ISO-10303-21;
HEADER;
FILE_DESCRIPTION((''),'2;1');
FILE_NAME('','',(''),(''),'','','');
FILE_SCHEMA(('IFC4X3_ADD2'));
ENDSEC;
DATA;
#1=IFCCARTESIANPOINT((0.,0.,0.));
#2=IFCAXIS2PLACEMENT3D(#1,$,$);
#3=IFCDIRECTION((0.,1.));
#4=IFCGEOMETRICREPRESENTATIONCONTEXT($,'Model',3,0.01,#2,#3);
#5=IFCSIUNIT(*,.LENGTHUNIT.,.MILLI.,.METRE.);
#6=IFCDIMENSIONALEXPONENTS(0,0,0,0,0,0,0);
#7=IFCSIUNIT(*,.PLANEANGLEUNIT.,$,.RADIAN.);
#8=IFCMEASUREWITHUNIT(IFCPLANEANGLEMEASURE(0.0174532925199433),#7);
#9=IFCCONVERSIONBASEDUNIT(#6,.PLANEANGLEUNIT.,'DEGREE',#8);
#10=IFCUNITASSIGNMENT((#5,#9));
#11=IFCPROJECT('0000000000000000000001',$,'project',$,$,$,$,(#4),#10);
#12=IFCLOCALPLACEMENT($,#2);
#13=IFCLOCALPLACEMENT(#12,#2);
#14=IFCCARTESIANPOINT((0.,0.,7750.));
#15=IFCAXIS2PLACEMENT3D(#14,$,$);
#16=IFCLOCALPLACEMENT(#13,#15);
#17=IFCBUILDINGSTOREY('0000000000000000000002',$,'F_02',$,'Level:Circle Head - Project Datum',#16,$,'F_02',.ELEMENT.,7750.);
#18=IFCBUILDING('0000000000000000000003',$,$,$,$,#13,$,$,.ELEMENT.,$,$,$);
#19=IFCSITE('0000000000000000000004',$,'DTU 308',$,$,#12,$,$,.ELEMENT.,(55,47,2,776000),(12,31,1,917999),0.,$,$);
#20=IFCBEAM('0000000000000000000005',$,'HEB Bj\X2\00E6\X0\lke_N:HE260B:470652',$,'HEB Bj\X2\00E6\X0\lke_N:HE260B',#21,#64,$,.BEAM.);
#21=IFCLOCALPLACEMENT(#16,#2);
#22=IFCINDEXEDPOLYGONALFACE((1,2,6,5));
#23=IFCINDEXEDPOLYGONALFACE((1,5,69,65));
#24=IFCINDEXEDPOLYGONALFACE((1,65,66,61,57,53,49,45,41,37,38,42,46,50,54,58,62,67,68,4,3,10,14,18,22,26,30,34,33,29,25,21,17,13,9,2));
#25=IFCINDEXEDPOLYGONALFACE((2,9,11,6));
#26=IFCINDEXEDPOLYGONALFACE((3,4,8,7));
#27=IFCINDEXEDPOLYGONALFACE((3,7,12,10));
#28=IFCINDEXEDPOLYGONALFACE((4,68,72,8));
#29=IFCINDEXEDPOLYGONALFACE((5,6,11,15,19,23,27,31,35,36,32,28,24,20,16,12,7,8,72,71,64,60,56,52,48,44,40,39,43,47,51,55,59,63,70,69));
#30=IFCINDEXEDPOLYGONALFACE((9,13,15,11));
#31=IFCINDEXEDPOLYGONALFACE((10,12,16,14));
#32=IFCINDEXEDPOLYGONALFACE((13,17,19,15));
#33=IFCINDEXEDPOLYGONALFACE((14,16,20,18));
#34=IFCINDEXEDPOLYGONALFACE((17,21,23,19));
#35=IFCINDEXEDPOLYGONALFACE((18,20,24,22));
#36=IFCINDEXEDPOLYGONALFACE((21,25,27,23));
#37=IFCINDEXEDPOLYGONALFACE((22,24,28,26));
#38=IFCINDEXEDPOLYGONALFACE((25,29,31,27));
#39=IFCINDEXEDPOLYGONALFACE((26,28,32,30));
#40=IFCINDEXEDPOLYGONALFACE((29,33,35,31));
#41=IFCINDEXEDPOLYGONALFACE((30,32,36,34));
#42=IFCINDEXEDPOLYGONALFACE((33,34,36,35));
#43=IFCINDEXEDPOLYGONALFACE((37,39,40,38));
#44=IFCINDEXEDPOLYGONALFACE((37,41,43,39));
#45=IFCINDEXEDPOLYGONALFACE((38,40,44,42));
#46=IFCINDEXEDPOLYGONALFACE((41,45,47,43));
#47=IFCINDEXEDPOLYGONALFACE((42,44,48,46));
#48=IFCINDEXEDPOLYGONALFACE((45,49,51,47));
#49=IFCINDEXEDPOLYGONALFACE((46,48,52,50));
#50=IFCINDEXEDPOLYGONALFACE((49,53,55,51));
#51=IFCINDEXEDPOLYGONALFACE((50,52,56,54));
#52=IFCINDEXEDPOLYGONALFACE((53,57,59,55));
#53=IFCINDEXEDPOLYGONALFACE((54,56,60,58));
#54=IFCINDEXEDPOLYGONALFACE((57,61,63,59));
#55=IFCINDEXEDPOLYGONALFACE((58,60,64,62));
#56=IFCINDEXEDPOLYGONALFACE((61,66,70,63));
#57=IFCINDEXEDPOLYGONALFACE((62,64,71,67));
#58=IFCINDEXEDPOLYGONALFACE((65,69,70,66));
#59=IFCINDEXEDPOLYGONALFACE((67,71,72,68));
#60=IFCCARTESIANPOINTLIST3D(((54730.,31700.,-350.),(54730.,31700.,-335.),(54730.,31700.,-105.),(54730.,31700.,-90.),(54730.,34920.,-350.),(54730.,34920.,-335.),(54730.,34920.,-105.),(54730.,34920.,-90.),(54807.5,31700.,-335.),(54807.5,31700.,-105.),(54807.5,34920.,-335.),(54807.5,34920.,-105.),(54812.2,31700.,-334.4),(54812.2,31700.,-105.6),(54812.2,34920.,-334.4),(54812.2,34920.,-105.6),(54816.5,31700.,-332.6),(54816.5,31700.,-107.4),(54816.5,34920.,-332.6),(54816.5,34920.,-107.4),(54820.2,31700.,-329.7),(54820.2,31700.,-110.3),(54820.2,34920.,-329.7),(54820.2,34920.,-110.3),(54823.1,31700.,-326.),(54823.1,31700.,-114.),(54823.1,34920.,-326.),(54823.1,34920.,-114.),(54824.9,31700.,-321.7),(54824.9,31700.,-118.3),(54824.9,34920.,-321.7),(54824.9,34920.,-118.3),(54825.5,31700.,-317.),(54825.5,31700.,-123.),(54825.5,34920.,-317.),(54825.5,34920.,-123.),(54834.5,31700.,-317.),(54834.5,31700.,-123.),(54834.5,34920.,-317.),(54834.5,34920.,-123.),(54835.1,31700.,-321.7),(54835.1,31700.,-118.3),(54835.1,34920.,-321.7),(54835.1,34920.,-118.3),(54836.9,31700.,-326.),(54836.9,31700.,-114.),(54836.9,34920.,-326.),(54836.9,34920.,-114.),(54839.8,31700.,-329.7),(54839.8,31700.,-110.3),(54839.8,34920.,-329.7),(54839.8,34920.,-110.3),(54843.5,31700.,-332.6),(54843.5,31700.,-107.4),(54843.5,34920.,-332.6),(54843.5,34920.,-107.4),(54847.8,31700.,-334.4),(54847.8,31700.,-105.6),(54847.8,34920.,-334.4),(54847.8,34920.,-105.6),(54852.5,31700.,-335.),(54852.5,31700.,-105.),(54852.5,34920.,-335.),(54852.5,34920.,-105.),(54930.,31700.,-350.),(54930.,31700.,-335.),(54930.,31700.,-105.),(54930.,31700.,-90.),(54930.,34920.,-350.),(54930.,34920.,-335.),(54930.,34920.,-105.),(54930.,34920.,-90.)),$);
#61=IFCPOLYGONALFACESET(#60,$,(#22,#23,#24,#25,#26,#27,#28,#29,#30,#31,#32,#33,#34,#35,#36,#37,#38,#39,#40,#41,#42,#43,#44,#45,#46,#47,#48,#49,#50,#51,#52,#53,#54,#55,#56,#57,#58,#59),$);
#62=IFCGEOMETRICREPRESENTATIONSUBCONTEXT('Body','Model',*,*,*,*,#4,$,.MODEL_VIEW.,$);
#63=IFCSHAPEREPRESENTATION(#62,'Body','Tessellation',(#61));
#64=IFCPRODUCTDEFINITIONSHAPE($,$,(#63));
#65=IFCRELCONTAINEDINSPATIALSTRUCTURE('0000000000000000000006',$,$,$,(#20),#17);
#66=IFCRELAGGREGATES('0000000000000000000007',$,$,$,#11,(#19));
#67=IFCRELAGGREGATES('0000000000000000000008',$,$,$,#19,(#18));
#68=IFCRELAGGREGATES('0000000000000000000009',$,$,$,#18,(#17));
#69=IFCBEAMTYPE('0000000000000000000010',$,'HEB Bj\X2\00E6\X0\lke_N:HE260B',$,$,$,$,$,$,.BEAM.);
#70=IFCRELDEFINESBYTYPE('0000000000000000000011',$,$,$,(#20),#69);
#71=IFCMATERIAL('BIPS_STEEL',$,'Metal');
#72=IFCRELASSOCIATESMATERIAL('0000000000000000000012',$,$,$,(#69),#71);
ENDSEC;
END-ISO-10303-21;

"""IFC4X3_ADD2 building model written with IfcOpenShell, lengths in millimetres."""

from ifc_helpers import new_model, entity, si_unit, converted_unit, direction, frame, frame_2d, origin, place, context, subcontext, project, spatial, polyline, circle_curve, parameter, trimmed, segment, composite_curve, i_section, outline, extrude, source, transform, mapped, material, material_profile, profile_set, type_object, element, save


model = new_model("IFC4X3_ADD2")

# Units and contexts
model_context = context("Model", 3, precision=0.01, world=origin(), true_north=direction((0.0, 1.0)))
body_context = subcontext(model_context, "Body", "Model", "MODEL_VIEW")
ifc_project = project(units=[si_unit("LENGTHUNIT", "METRE", prefix="MILLI"), converted_unit("PLANEANGLEUNIT", "DEGREE", entity("IfcPlaneAngleMeasure", 0.0174532925199433), si_unit("PLANEANGLEUNIT", "RADIAN"), dimensions=[0, 0, 0, 0, 0, 0, 0])], contexts=[model_context])

# Site, building, storey
site_placement = place(None, origin())
site = spatial("IfcSite", under=ifc_project, at=site_placement, Name="DTU 308", CompositionType="ELEMENT", RefLatitude=(55, 47, 2, 776000), RefLongitude=(12, 31, 1, 917999), RefElevation=0.0)
building_placement = place(site_placement, origin())
building = spatial("IfcBuilding", under=site, at=building_placement, CompositionType="ELEMENT")
storey_placement = place(building_placement, frame((0.0, 0.0, 7750.0)))
storey = spatial("IfcBuildingStorey", under=building, at=storey_placement, Name="F_02", ObjectType="Level:Circle Head - Project Datum", LongName="F_02", CompositionType="ELEMENT", Elevation=7750.0)

# Shared definitions
ifc_material = material(Name="BIPS_STEEL", Category="Metal")

# Beam
ifc_material_profile_1 = material_profile(ifc_material, i_section(OverallWidth=200.0, OverallDepth=260.0, WebThickness=9.0, FlangeThickness=15.0, FilletRadius=18.0, at=frame_2d((0.0, 0.0), x_axis=(1.0, 0.0))), Name="HE260B")
ifc_profile_set_1 = profile_set([ifc_material_profile_1], Name="HE260B")
beam_type_1 = type_object("IfcBeamType", Name="HEB Bjælke_N:HE260B", PredefinedType="BEAM", material=ifc_profile_set_1)
shared_shape_1 = source(origin(), body_context, "Body", "SweptSolid", [
    extrude(outline(composite_curve([segment(polyline([(-100.0, -115.0), (-100.0, -130.0)]), True, "CONTINUOUS"), segment(polyline([(-100.0, -130.0), (100.0, -130.0)]), True, "CONTINUOUS"), segment(polyline([(100.0, -130.0), (100.0, -115.0)]), True, "CONTINUOUS"), segment(polyline([(100.0, -115.0), (22.5, -115.0)]), True, "CONTINUOUS"), segment(trimmed(circle_curve(frame_2d((22.5, -97.0), x_axis=(1.0, 0.0)), 18.0), [parameter(180.0)], [parameter(270.0)], True, "PARAMETER"), False, "CONTINUOUS"), segment(polyline([(4.5, -97.0), (4.5, 97.0)]), True, "CONTINUOUS"), segment(trimmed(circle_curve(frame_2d((22.5, 97.0), x_axis=(1.0, 0.0)), 18.0), [parameter(90.0)], [parameter(180.0)], True, "PARAMETER"), False, "CONTINUOUS"), segment(polyline([(22.5, 115.0), (100.0, 115.0)]), True, "CONTINUOUS"), segment(polyline([(100.0, 115.0), (100.0, 130.0)]), True, "CONTINUOUS"), segment(polyline([(100.0, 130.0), (-100.0, 130.0)]), True, "CONTINUOUS"), segment(polyline([(-100.0, 130.0), (-100.0, 115.0)]), True, "CONTINUOUS"), segment(polyline([(-100.0, 115.0), (-22.5, 115.0)]), True, "CONTINUOUS"), segment(trimmed(circle_curve(frame_2d((-22.5, 97.0), x_axis=(1.0, 0.0)), 18.0), [parameter(360.0)], [parameter(90.0)], True, "PARAMETER"), False, "CONTINUOUS"), segment(polyline([(-4.5, 97.0), (-4.5, -97.0)]), True, "CONTINUOUS"), segment(trimmed(circle_curve(frame_2d((-22.5, -97.0), x_axis=(1.0, 0.0)), 18.0), [parameter(270.0)], [parameter(360.0)], True, "PARAMETER"), False, "CONTINUOUS"), segment(polyline([(-22.5, -115.0), (-100.0, -115.0)]), True, "CONTINUOUS")], self_intersect=False)), frame((-1720.0, 0.0, 0.0), z_axis=(-1.0, 0.0, 0.0), x_axis=(0.0, -1.0, 0.0)), (0.0, 0.0, -1.0), 3220.0),
])
beam_1_placement = place(storey_placement, frame((54830.0, 33200.0, -220.0), z_axis=(0.0, 0.0, 1.0), x_axis=(0.0, -1.0, 0.0)))
element("IfcBeam", 1, at=beam_1_placement, inside=storey, type_object=beam_type_1, Name="HEB Bjælke_N:HE260B:470652", ObjectType="HEB Bjælke_N:HE260B", PredefinedType="BEAM", context=body_context, shape_type="MappedRepresentation", body=[
    mapped(shared_shape_1, transform((0.0, 0.0, 0.0), scale=1.0)),
])

save(model, "model.ifc")
